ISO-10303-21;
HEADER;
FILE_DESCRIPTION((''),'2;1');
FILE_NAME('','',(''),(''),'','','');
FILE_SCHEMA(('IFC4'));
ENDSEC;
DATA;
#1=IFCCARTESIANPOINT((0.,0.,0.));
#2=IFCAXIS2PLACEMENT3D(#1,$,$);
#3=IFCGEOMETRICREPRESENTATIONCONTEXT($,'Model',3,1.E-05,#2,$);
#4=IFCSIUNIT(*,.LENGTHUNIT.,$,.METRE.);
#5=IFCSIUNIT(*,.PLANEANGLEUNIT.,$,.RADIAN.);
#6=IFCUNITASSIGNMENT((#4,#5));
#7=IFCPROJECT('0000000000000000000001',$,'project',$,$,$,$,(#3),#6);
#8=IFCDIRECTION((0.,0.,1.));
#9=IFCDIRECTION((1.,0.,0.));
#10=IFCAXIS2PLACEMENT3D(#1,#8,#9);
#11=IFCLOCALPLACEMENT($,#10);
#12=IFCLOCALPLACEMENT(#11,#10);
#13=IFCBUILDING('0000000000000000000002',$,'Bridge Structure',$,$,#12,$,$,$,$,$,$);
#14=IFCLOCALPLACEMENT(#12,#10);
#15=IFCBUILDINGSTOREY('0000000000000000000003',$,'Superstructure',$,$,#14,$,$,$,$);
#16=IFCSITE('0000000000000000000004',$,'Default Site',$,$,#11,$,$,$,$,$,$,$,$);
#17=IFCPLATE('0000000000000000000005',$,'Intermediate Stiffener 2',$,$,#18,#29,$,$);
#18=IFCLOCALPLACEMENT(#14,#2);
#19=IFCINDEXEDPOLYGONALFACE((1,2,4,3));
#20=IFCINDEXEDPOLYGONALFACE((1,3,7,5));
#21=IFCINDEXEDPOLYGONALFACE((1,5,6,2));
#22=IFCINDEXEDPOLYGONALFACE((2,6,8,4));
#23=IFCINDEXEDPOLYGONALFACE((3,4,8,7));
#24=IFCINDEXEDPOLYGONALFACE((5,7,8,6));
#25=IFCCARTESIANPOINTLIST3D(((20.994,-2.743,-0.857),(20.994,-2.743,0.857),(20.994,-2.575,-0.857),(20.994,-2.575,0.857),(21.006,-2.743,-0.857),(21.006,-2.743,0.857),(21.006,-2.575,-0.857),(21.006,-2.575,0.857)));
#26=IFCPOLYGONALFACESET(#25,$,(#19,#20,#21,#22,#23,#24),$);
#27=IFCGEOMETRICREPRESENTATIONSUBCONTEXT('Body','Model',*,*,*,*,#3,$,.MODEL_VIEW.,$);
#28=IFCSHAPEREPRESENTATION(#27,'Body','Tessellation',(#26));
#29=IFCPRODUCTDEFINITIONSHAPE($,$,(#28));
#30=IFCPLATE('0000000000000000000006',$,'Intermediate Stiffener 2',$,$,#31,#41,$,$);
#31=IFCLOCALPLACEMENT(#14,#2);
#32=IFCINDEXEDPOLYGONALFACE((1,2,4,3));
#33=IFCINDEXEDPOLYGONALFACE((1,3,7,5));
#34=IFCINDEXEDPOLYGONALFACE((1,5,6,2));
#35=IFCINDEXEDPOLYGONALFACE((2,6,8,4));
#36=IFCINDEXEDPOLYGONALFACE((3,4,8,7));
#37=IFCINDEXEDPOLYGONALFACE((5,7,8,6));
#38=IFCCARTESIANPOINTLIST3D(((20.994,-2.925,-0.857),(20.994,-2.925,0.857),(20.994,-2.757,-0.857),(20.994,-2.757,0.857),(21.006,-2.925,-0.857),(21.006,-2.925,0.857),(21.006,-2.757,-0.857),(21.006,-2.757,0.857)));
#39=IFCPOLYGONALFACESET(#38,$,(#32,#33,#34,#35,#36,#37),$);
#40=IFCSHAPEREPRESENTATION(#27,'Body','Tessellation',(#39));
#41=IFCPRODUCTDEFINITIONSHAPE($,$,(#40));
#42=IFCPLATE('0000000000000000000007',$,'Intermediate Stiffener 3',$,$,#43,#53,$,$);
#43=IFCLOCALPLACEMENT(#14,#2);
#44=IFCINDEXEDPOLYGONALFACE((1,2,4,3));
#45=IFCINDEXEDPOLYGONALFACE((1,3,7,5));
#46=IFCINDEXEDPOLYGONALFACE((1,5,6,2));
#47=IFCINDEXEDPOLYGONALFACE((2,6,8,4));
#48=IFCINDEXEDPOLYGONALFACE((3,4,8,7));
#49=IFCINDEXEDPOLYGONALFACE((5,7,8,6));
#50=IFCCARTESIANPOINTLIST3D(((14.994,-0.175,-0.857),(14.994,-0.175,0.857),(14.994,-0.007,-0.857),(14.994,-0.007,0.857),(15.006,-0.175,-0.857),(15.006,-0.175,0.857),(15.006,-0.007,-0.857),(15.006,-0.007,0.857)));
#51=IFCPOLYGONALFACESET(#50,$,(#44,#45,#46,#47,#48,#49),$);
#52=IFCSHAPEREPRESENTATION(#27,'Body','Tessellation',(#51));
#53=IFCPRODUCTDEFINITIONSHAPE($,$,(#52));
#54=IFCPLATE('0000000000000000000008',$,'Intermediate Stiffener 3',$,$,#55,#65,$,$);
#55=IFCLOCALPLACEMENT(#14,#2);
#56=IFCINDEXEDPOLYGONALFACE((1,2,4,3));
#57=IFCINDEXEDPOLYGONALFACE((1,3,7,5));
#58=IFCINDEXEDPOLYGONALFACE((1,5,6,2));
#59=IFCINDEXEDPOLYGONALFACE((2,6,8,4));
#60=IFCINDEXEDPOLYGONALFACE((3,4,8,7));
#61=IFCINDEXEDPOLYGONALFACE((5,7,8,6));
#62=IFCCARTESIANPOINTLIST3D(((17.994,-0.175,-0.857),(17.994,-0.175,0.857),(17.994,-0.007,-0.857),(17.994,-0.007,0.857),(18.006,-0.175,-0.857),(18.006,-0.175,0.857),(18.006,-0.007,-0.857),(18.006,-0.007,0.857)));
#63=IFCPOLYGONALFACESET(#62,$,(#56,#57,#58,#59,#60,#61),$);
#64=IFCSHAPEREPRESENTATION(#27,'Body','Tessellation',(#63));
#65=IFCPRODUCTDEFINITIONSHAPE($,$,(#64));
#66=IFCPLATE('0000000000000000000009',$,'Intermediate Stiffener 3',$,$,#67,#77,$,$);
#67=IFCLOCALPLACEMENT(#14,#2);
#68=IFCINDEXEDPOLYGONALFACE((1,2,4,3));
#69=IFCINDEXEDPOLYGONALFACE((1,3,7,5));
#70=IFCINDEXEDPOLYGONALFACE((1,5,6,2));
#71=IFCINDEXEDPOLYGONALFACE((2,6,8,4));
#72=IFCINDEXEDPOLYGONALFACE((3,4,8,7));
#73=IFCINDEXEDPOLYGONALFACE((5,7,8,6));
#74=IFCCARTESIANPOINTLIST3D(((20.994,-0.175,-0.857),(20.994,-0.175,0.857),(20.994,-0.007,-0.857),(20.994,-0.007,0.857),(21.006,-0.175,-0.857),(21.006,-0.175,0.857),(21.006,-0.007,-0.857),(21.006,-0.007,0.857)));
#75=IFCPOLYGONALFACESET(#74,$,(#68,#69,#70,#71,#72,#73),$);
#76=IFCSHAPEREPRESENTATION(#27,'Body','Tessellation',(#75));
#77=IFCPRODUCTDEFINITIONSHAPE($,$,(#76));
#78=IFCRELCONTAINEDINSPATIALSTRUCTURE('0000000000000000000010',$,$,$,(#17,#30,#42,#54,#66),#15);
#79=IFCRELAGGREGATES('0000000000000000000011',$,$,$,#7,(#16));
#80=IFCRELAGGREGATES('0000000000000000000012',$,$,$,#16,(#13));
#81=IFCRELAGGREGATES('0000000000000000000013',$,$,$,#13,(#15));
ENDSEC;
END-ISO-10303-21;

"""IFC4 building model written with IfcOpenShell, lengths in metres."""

from ifc_helpers import new_model, si_unit, frame, origin, origin_with_axes, origin_2d_with_axis, place, context, subcontext, project, spatial, rectangle, extrude, element, save


model = new_model("IFC4")

# Units and contexts
model_context = context("Model", 3, precision=1e-05, world=origin())
body_context = subcontext(model_context, "Body", "Model", "MODEL_VIEW")
ifc_project = project(units=[si_unit("LENGTHUNIT", "METRE"), si_unit("PLANEANGLEUNIT", "RADIAN")], contexts=[model_context])

# Site, building, storey
site_placement = place(None, origin_with_axes())
site = spatial("IfcSite", under=ifc_project, at=site_placement, Name="Default Site")
building_placement = place(site_placement, origin_with_axes())
building = spatial("IfcBuilding", under=site, at=building_placement, Name="Bridge Structure")
storey_placement = place(building_placement, origin_with_axes())
storey = spatial("IfcBuildingStorey", under=building, at=storey_placement, Name="Superstructure")

# Plates
for number, where, z_axis, x_axis, name in (
    (1, (21.0, -2.659, -0.857), (0.0, 0.0, 1.0), (1.0, 0.0, 0.0), "Intermediate Stiffener 2"),
    (2, (21.0, -2.841, -0.857), (0.0, 0.0, 1.0), (1.0, 0.0, 0.0), "Intermediate Stiffener 2"),
    (3, (15.0, -0.091, -0.857), (0.0, 0.0, 1.0), (1.0, 0.0, 0.0), "Intermediate Stiffener 3"),
    (4, (18.0, -0.091, -0.857), (0.0, 0.0, 1.0), (1.0, 0.0, 0.0), "Intermediate Stiffener 3"),
    (5, (21.0, -0.091, -0.857), (0.0, 0.0, 1.0), (1.0, 0.0, 0.0), "Intermediate Stiffener 3"),
):
    element("IfcPlate", number, at=place(storey_placement, frame(where, z_axis=z_axis, x_axis=x_axis)), inside=storey, Name=name, context=body_context, shape_type="SweptSolid", body=[
        extrude(rectangle(XDim=0.012, YDim=0.168, at=origin_2d_with_axis()), origin_with_axes(), (0.0, 0.0, 1.0), 1.714),
    ])

save(model, "model.ifc")
